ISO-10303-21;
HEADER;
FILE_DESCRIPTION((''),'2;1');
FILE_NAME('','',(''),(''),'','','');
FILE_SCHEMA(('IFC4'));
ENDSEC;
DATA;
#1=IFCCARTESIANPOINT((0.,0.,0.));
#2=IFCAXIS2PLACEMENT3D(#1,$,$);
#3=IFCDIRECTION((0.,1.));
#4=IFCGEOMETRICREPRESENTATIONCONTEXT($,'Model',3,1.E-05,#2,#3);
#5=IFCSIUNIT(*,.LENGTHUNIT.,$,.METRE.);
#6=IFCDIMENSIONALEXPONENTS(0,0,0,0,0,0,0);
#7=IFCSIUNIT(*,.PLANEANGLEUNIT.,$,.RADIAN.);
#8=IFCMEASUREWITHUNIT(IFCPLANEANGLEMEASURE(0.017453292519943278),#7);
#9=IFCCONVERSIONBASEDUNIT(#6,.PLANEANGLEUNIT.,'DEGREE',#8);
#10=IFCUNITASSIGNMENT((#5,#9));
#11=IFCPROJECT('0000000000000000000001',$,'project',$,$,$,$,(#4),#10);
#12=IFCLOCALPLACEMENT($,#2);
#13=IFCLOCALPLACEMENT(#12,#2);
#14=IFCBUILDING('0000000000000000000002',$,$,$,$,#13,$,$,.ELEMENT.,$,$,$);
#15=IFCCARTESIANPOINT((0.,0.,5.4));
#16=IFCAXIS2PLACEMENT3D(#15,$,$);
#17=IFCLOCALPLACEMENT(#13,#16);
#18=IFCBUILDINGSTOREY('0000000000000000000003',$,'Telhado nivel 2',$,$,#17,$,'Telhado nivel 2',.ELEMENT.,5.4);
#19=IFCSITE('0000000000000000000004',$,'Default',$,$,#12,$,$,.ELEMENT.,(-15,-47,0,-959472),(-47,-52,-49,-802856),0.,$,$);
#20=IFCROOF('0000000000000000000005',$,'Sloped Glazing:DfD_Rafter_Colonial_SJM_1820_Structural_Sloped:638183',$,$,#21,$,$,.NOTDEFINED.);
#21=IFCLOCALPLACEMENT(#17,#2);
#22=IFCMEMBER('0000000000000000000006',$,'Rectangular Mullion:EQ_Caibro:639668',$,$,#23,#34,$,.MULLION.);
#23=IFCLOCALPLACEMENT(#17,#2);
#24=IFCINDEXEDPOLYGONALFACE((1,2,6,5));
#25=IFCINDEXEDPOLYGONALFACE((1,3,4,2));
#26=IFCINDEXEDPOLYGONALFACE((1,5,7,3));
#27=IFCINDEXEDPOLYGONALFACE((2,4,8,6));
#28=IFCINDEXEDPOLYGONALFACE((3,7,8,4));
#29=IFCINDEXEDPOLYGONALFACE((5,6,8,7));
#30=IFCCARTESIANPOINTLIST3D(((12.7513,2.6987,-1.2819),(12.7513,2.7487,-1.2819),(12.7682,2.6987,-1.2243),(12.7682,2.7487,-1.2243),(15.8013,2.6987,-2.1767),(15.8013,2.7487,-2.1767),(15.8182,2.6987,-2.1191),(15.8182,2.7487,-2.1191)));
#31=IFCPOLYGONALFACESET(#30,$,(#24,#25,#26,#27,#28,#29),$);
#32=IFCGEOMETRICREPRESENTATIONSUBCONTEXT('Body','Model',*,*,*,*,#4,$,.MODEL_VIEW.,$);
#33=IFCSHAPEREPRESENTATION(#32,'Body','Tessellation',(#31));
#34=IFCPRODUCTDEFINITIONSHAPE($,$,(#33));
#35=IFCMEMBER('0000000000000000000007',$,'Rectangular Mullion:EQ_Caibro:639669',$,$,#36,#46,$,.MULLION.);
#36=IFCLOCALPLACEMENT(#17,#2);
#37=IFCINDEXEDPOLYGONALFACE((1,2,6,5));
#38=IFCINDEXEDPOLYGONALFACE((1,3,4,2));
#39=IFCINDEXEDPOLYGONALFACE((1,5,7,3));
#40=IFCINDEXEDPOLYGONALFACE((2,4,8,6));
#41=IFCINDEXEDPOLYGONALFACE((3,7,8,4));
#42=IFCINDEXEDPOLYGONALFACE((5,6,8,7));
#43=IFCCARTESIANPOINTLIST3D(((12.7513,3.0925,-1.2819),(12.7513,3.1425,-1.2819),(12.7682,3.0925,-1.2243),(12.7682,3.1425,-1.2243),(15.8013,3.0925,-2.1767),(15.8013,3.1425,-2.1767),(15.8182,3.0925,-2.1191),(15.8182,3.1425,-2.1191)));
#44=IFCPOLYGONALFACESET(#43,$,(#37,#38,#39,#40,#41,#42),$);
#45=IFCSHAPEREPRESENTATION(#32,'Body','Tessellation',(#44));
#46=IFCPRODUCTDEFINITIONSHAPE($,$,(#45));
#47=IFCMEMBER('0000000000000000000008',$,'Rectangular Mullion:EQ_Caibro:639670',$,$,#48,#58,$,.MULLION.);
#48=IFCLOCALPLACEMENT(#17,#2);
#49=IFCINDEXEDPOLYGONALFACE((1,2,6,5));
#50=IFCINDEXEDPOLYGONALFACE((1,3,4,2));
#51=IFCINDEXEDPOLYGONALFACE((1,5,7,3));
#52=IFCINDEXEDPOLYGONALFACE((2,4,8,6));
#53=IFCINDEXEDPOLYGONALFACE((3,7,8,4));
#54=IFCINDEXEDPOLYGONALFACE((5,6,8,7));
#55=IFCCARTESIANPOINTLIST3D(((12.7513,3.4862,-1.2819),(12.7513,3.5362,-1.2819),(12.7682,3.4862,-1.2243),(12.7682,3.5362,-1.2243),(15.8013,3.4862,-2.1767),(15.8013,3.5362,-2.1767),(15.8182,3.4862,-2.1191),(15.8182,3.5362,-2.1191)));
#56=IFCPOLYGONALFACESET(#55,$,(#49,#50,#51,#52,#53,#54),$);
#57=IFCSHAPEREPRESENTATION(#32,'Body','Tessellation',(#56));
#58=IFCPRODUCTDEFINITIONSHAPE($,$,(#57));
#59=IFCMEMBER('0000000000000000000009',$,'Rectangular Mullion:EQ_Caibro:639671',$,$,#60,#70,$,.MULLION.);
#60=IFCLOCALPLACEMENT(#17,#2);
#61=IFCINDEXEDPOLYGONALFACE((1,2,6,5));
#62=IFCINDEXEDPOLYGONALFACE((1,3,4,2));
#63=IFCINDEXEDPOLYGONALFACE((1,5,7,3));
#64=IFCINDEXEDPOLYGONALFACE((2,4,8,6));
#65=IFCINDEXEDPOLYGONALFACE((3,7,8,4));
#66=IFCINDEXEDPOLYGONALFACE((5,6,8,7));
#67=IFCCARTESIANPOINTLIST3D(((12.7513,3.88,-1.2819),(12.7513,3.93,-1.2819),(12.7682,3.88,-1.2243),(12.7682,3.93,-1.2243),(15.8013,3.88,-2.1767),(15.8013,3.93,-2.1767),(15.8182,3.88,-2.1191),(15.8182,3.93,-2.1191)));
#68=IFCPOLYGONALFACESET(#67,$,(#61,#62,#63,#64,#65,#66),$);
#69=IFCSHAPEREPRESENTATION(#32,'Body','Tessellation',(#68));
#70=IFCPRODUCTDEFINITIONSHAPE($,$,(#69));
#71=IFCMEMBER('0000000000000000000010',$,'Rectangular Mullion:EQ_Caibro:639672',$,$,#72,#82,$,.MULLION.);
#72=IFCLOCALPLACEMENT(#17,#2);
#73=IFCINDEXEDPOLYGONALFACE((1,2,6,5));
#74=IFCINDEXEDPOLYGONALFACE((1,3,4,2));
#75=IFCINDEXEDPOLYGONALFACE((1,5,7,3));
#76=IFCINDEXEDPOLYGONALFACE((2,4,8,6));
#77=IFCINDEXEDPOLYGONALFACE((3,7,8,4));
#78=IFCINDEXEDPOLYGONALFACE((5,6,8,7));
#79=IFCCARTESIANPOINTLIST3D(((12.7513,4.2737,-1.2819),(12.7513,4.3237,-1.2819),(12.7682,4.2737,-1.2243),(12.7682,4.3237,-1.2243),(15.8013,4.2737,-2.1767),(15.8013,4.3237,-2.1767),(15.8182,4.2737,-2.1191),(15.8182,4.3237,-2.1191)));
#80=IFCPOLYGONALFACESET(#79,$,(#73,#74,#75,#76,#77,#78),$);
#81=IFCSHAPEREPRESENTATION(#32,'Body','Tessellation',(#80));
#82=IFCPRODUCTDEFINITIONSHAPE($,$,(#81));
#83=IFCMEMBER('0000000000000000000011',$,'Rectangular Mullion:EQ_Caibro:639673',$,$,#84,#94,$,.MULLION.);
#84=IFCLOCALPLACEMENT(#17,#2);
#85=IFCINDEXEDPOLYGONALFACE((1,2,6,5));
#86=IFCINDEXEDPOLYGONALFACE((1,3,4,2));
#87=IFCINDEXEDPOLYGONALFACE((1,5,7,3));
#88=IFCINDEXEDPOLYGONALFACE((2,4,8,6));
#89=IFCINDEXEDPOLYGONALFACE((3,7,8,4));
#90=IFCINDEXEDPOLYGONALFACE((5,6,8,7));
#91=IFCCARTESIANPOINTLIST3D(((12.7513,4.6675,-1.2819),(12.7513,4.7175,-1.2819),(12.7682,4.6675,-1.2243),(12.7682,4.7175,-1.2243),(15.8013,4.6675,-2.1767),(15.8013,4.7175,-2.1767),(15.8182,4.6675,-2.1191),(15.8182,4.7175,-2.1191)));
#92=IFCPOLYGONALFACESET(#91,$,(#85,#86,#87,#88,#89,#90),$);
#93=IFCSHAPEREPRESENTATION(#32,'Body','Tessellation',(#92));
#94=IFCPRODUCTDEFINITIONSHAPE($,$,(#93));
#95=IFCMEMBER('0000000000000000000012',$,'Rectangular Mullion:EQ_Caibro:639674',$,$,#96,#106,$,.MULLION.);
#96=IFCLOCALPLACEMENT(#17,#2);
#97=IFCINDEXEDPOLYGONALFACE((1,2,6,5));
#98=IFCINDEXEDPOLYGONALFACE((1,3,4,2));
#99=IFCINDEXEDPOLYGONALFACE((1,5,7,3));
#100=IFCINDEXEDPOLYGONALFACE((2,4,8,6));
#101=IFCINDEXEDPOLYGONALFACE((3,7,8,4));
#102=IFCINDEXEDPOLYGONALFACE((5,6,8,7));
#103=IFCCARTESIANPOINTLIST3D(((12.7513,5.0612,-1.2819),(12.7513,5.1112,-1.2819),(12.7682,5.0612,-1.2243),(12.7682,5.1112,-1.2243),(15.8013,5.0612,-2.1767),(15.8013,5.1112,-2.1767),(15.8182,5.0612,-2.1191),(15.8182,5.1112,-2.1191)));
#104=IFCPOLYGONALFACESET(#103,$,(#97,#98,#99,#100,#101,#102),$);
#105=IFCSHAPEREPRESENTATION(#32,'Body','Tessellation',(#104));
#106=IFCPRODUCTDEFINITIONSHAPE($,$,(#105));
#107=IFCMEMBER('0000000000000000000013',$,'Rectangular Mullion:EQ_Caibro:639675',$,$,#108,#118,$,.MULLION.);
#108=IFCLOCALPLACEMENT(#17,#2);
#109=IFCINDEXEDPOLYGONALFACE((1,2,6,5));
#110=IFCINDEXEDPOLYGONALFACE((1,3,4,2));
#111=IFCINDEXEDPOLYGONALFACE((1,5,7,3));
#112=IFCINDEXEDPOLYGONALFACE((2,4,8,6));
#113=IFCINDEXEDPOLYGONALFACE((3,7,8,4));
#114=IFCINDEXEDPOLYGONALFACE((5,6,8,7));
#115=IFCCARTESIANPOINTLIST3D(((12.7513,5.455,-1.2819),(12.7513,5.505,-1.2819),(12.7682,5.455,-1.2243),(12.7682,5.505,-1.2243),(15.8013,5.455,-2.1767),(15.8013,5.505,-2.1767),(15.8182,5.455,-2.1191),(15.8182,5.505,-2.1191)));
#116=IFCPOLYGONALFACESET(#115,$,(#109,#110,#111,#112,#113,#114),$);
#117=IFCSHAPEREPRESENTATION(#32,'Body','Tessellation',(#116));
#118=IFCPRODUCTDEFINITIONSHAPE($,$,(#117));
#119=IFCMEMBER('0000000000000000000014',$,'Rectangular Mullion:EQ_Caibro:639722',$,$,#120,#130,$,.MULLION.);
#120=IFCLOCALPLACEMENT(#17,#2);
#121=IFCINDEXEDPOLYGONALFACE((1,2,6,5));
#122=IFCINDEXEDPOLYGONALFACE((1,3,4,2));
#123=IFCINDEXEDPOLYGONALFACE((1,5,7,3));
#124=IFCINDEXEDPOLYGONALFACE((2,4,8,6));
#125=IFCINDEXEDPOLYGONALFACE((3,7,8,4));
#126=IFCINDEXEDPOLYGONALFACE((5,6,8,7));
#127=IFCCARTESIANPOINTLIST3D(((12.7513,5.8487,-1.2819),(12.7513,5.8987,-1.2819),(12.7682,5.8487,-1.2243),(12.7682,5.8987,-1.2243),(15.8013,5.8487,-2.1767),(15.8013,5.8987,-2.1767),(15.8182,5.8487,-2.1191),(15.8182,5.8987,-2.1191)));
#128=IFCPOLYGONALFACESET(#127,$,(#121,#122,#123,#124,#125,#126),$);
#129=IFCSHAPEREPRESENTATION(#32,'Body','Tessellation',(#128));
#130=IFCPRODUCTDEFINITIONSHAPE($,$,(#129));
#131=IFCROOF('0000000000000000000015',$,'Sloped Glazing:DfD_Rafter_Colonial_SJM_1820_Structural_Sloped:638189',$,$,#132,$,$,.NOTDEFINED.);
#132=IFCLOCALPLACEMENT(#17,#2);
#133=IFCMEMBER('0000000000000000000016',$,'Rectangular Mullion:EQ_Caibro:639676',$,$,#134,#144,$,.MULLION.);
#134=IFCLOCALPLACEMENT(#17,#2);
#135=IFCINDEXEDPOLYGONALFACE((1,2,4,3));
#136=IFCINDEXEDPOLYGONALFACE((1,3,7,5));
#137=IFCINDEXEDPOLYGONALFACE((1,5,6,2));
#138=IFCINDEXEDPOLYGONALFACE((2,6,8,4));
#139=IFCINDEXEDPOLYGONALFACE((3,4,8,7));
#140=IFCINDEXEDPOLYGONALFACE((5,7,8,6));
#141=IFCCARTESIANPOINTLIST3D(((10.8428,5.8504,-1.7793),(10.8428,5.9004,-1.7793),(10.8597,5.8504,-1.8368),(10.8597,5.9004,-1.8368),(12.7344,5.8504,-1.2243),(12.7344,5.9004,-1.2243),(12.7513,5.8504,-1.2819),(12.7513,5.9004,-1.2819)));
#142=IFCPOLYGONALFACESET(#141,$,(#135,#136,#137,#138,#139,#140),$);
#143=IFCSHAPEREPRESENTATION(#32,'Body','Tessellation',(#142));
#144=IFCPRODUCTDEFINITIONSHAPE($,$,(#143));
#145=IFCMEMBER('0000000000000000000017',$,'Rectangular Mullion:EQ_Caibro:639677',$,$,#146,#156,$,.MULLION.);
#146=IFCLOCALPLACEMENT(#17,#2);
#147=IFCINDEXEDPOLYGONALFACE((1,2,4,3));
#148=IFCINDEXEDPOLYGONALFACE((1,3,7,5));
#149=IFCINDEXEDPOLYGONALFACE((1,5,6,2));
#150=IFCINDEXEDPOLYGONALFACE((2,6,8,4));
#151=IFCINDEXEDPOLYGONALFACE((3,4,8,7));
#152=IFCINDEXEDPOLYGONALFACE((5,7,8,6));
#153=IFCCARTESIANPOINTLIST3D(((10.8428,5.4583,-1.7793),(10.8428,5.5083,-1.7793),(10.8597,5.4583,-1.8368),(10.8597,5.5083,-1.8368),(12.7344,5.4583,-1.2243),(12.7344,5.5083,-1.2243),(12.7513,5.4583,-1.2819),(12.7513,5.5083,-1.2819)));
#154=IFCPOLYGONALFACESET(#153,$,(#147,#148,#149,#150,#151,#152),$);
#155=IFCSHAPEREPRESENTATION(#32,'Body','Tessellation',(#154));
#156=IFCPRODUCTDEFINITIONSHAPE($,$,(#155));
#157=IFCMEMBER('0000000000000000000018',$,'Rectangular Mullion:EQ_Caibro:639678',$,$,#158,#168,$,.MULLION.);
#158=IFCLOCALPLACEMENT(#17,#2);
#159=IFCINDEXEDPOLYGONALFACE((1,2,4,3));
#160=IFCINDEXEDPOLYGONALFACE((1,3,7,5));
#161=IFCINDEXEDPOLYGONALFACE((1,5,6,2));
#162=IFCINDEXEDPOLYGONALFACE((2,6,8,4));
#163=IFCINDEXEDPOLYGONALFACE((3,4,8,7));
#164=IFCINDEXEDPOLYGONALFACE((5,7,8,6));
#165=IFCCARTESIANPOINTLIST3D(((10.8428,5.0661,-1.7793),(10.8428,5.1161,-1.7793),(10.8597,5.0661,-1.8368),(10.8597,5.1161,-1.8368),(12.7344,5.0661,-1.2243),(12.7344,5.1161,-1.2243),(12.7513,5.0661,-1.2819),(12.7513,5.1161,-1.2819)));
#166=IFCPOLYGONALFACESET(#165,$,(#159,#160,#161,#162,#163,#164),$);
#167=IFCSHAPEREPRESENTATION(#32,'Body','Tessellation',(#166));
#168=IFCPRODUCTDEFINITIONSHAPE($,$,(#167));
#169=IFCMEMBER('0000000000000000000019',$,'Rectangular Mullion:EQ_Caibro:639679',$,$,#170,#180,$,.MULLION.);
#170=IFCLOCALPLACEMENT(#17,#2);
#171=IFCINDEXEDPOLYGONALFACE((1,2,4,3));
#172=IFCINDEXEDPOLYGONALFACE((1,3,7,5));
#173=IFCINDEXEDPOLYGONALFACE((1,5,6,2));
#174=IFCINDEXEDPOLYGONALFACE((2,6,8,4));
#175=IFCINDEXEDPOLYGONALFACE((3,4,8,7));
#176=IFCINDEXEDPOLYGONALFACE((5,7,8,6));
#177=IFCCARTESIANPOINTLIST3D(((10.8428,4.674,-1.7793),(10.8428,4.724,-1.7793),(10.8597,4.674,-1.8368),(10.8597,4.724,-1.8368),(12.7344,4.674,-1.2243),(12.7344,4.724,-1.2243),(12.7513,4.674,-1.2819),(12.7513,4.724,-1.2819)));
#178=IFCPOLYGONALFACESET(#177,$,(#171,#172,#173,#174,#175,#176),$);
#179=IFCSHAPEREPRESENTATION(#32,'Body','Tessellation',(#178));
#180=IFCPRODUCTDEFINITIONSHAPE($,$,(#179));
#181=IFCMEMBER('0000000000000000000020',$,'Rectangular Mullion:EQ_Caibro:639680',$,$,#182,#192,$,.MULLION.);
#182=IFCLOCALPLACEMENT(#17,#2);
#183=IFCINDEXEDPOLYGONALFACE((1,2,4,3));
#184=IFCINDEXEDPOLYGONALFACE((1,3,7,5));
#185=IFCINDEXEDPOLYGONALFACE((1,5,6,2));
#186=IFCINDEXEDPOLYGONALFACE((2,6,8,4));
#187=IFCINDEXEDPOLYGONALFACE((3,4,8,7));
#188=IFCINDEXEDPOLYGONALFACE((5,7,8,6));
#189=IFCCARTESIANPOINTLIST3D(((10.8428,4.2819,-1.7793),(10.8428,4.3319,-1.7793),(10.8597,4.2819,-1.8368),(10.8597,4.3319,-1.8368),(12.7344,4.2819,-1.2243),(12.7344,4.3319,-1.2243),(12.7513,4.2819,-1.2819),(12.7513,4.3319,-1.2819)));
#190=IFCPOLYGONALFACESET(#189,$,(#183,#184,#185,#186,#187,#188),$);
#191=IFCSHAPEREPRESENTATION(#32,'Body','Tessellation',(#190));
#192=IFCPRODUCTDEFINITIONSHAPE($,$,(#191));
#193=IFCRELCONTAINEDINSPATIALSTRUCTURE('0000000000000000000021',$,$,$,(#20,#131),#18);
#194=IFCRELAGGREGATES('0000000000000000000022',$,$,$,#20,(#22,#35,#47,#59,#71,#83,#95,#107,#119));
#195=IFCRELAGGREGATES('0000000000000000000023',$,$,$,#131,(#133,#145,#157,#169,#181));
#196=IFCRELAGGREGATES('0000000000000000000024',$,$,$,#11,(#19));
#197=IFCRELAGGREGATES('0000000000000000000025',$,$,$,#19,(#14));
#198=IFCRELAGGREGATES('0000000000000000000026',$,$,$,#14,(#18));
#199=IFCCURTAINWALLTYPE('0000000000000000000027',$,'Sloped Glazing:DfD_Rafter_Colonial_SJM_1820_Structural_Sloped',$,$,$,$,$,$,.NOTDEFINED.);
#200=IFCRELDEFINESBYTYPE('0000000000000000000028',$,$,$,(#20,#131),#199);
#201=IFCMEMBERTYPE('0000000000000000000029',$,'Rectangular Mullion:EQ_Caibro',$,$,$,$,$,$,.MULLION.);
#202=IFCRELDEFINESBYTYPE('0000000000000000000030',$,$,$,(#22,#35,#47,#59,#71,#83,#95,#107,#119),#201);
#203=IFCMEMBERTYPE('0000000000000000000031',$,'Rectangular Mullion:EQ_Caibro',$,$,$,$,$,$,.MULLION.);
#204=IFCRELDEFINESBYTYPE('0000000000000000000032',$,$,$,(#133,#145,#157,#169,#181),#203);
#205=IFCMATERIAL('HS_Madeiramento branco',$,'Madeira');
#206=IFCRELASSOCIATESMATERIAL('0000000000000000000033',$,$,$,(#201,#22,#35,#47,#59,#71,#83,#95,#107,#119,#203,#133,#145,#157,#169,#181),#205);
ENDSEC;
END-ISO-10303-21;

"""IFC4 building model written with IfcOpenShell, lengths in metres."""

from ifc_helpers import new_model, entity, si_unit, converted_unit, direction, frame, origin, place, context, subcontext, project, spatial, indexed_curve, outline, extrude, source, transform, mapped, material, type_object, type_shapes, element, aggregate, save


model = new_model("IFC4")

# Units and contexts
model_context = context("Model", 3, precision=1e-05, world=origin(), true_north=direction((0.0, 1.0)))
body_context = subcontext(model_context, "Body", "Model", "MODEL_VIEW")
ifc_project = project(units=[si_unit("LENGTHUNIT", "METRE"), converted_unit("PLANEANGLEUNIT", "DEGREE", entity("IfcPlaneAngleMeasure", 0.017453292519943278), si_unit("PLANEANGLEUNIT", "RADIAN"), dimensions=[0, 0, 0, 0, 0, 0, 0])], contexts=[model_context])

# Site, building, storey
site_placement = place(None, origin())
site = spatial("IfcSite", under=ifc_project, at=site_placement, Name="Default", CompositionType="ELEMENT", RefLatitude=(-15, -47, 0, -959472), RefLongitude=(-47, -52, -49, -802856), RefElevation=0.0)
building_placement = place(site_placement, origin())
building = spatial("IfcBuilding", under=site, at=building_placement, CompositionType="ELEMENT")
storey_placement = place(building_placement, frame((0.0, 0.0, 5.4)))
storey = spatial("IfcBuildingStorey", under=building, at=storey_placement, Name="Telhado nivel 2", LongName="Telhado nivel 2", CompositionType="ELEMENT", Elevation=5.4)

# Roofs, members
curtain_wall_type = type_object("IfcCurtainWallType", Name="Sloped Glazing:DfD_Rafter_Colonial_SJM_1820_Structural_Sloped", PredefinedType="NOTDEFINED")
roof_1_placement = place(storey_placement, frame((0.0, 0.0, -5.4)))
roof_1 = element("IfcRoof", 1, at=roof_1_placement, inside=storey, type_object=curtain_wall_type, Name="Sloped Glazing:DfD_Rafter_Colonial_SJM_1820_Structural_Sloped:638183", PredefinedType="NOTDEFINED")
ifc_material = material(Name="HS_Madeiramento branco", Category="Madeira")
member_type_1 = type_object("IfcMemberType", Name="Rectangular Mullion:EQ_Caibro", PredefinedType="MULLION", material=ifc_material)
shared_shape_1 = source(origin(), body_context, "Body", "SweptSolid", [
    extrude(outline(indexed_curve([(-0.025, -0.03), (0.025, -0.03), (0.025, 0.03), (-0.025, 0.03), (-0.025, -0.03)], self_intersect=False)), frame((0.0, -0.03, -3.1785), z_axis=(0.0, 0.0, 1.0), x_axis=(-1.0, 0.0, 0.0)), (0.0, 0.0, 1.0), 3.1785),
])
type_shapes(member_type_1, [shared_shape_1])
member_1_placement = place(roof_1_placement, frame((12.7513, 2.7237, 4.1181), z_axis=(-0.95956, 0.0, 0.281504), x_axis=(0.0, 1.0, 0.0)))
member_1 = element("IfcMember", 2, at=member_1_placement, type_object=member_type_1, material=ifc_material, Name="Rectangular Mullion:EQ_Caibro:639668", PredefinedType="MULLION", context=body_context, shape_type="MappedRepresentation", body=[
    mapped(shared_shape_1, transform((0.0, 0.0, 0.0), scale=1.0)),
])
member_2_placement = place(roof_1_placement, frame((12.7513, 3.1175, 4.1181), z_axis=(-0.95956, 0.0, 0.281504), x_axis=(0.0, 1.0, 0.0)))
member_2 = element("IfcMember", 3, at=member_2_placement, type_object=member_type_1, material=ifc_material, Name="Rectangular Mullion:EQ_Caibro:639669", PredefinedType="MULLION", context=body_context, shape_type="MappedRepresentation", body=[
    mapped(shared_shape_1, transform((0.0, 0.0, 0.0), scale=1.0)),
])
member_3_placement = place(roof_1_placement, frame((12.7513, 3.5112, 4.1181), z_axis=(-0.95956, 0.0, 0.281504), x_axis=(0.0, 1.0, 0.0)))
member_3 = element("IfcMember", 4, at=member_3_placement, type_object=member_type_1, material=ifc_material, Name="Rectangular Mullion:EQ_Caibro:639670", PredefinedType="MULLION", context=body_context, shape_type="MappedRepresentation", body=[
    mapped(shared_shape_1, transform((0.0, 0.0, 0.0), scale=1.0)),
])
member_4_placement = place(roof_1_placement, frame((12.7513, 3.905, 4.1181), z_axis=(-0.95956, 0.0, 0.281504), x_axis=(0.0, 1.0, 0.0)))
member_4 = element("IfcMember", 5, at=member_4_placement, type_object=member_type_1, material=ifc_material, Name="Rectangular Mullion:EQ_Caibro:639671", PredefinedType="MULLION", context=body_context, shape_type="MappedRepresentation", body=[
    mapped(shared_shape_1, transform((0.0, 0.0, 0.0), scale=1.0)),
])
member_5_placement = place(roof_1_placement, frame((12.7513, 4.2987, 4.1181), z_axis=(-0.95956, 0.0, 0.281504), x_axis=(0.0, 1.0, 0.0)))
member_5 = element("IfcMember", 6, at=member_5_placement, type_object=member_type_1, material=ifc_material, Name="Rectangular Mullion:EQ_Caibro:639672", PredefinedType="MULLION", context=body_context, shape_type="MappedRepresentation", body=[
    mapped(shared_shape_1, transform((0.0, 0.0, 0.0), scale=1.0)),
])
member_6_placement = place(roof_1_placement, frame((12.7513, 4.6925, 4.1181), z_axis=(-0.95956, 0.0, 0.281504), x_axis=(0.0, 1.0, 0.0)))
member_6 = element("IfcMember", 7, at=member_6_placement, type_object=member_type_1, material=ifc_material, Name="Rectangular Mullion:EQ_Caibro:639673", PredefinedType="MULLION", context=body_context, shape_type="MappedRepresentation", body=[
    mapped(shared_shape_1, transform((0.0, 0.0, 0.0), scale=1.0)),
])
member_7_placement = place(roof_1_placement, frame((12.7513, 5.0862, 4.1181), z_axis=(-0.95956, 0.0, 0.281504), x_axis=(0.0, 1.0, 0.0)))
member_7 = element("IfcMember", 8, at=member_7_placement, type_object=member_type_1, material=ifc_material, Name="Rectangular Mullion:EQ_Caibro:639674", PredefinedType="MULLION", context=body_context, shape_type="MappedRepresentation", body=[
    mapped(shared_shape_1, transform((0.0, 0.0, 0.0), scale=1.0)),
])
member_8_placement = place(roof_1_placement, frame((12.7513, 5.48, 4.1181), z_axis=(-0.95956, 0.0, 0.281504), x_axis=(0.0, 1.0, 0.0)))
member_8 = element("IfcMember", 9, at=member_8_placement, type_object=member_type_1, material=ifc_material, Name="Rectangular Mullion:EQ_Caibro:639675", PredefinedType="MULLION", context=body_context, shape_type="MappedRepresentation", body=[
    mapped(shared_shape_1, transform((0.0, 0.0, 0.0), scale=1.0)),
])
member_9_placement = place(roof_1_placement, frame((12.7513, 5.8737, 4.1181), z_axis=(-0.95956, 0.0, 0.281504), x_axis=(0.0, 1.0, 0.0)))
member_9 = element("IfcMember", 10, at=member_9_placement, type_object=member_type_1, material=ifc_material, Name="Rectangular Mullion:EQ_Caibro:639722", PredefinedType="MULLION", context=body_context, shape_type="MappedRepresentation", body=[
    mapped(shared_shape_1, transform((0.0, 0.0, 0.0), scale=1.0)),
])
aggregate(roof_1, [member_1, member_2, member_3, member_4, member_5, member_6, member_7, member_8, member_9])
roof_2_placement = place(storey_placement, frame((0.0, 0.0, -5.4)))
roof_2 = element("IfcRoof", 11, at=roof_2_placement, inside=storey, type_object=curtain_wall_type, Name="Sloped Glazing:DfD_Rafter_Colonial_SJM_1820_Structural_Sloped:638189", PredefinedType="NOTDEFINED")
member_type_2 = type_object("IfcMemberType", Name="Rectangular Mullion:EQ_Caibro", PredefinedType="MULLION", material=ifc_material)
shared_shape_2 = source(origin(), body_context, "Body", "SweptSolid", [
    extrude(outline(indexed_curve([(-0.025, -0.03), (0.025, -0.03), (0.025, 0.03), (-0.025, 0.03), (-0.025, -0.03)], self_intersect=False)), frame((0.0, -0.03, -1.9713), z_axis=(0.0, 0.0, 1.0), x_axis=(-1.0, 0.0, 0.0)), (0.0, 0.0, 1.0), 1.9713),
])
type_shapes(member_type_2, [shared_shape_2])
member_10_placement = place(roof_2_placement, frame((12.7513, 5.8754, 4.1181), z_axis=(0.95956, 0.0, 0.281504), x_axis=(0.0, -1.0, 0.0)))
member_10 = element("IfcMember", 12, at=member_10_placement, type_object=member_type_2, material=ifc_material, Name="Rectangular Mullion:EQ_Caibro:639676", PredefinedType="MULLION", context=body_context, shape_type="MappedRepresentation", body=[
    mapped(shared_shape_2, transform((0.0, 0.0, 0.0), scale=1.0)),
])
member_11_placement = place(roof_2_placement, frame((12.7513, 5.4833, 4.1181), z_axis=(0.95956, 0.0, 0.281504), x_axis=(0.0, -1.0, 0.0)))
member_11 = element("IfcMember", 13, at=member_11_placement, type_object=member_type_2, material=ifc_material, Name="Rectangular Mullion:EQ_Caibro:639677", PredefinedType="MULLION", context=body_context, shape_type="MappedRepresentation", body=[
    mapped(shared_shape_2, transform((0.0, 0.0, 0.0), scale=1.0)),
])
member_12_placement = place(roof_2_placement, frame((12.7513, 5.0911, 4.1181), z_axis=(0.95956, 0.0, 0.281504), x_axis=(0.0, -1.0, 0.0)))
member_12 = element("IfcMember", 14, at=member_12_placement, type_object=member_type_2, material=ifc_material, Name="Rectangular Mullion:EQ_Caibro:639678", PredefinedType="MULLION", context=body_context, shape_type="MappedRepresentation", body=[
    mapped(shared_shape_2, transform((0.0, 0.0, 0.0), scale=1.0)),
])
member_13_placement = place(roof_2_placement, frame((12.7513, 4.699, 4.1181), z_axis=(0.95956, 0.0, 0.281504), x_axis=(0.0, -1.0, 0.0)))
member_13 = element("IfcMember", 15, at=member_13_placement, type_object=member_type_2, material=ifc_material, Name="Rectangular Mullion:EQ_Caibro:639679", PredefinedType="MULLION", context=body_context, shape_type="MappedRepresentation", body=[
    mapped(shared_shape_2, transform((0.0, 0.0, 0.0), scale=1.0)),
])
member_14_placement = place(roof_2_placement, frame((12.7513, 4.3069, 4.1181), z_axis=(0.95956, 0.0, 0.281504), x_axis=(0.0, -1.0, 0.0)))
member_14 = element("IfcMember", 16, at=member_14_placement, type_object=member_type_2, material=ifc_material, Name="Rectangular Mullion:EQ_Caibro:639680", PredefinedType="MULLION", context=body_context, shape_type="MappedRepresentation", body=[
    mapped(shared_shape_2, transform((0.0, 0.0, 0.0), scale=1.0)),
])
aggregate(roof_2, [member_10, member_11, member_12, member_13, member_14])

save(model, "model.ifc")
